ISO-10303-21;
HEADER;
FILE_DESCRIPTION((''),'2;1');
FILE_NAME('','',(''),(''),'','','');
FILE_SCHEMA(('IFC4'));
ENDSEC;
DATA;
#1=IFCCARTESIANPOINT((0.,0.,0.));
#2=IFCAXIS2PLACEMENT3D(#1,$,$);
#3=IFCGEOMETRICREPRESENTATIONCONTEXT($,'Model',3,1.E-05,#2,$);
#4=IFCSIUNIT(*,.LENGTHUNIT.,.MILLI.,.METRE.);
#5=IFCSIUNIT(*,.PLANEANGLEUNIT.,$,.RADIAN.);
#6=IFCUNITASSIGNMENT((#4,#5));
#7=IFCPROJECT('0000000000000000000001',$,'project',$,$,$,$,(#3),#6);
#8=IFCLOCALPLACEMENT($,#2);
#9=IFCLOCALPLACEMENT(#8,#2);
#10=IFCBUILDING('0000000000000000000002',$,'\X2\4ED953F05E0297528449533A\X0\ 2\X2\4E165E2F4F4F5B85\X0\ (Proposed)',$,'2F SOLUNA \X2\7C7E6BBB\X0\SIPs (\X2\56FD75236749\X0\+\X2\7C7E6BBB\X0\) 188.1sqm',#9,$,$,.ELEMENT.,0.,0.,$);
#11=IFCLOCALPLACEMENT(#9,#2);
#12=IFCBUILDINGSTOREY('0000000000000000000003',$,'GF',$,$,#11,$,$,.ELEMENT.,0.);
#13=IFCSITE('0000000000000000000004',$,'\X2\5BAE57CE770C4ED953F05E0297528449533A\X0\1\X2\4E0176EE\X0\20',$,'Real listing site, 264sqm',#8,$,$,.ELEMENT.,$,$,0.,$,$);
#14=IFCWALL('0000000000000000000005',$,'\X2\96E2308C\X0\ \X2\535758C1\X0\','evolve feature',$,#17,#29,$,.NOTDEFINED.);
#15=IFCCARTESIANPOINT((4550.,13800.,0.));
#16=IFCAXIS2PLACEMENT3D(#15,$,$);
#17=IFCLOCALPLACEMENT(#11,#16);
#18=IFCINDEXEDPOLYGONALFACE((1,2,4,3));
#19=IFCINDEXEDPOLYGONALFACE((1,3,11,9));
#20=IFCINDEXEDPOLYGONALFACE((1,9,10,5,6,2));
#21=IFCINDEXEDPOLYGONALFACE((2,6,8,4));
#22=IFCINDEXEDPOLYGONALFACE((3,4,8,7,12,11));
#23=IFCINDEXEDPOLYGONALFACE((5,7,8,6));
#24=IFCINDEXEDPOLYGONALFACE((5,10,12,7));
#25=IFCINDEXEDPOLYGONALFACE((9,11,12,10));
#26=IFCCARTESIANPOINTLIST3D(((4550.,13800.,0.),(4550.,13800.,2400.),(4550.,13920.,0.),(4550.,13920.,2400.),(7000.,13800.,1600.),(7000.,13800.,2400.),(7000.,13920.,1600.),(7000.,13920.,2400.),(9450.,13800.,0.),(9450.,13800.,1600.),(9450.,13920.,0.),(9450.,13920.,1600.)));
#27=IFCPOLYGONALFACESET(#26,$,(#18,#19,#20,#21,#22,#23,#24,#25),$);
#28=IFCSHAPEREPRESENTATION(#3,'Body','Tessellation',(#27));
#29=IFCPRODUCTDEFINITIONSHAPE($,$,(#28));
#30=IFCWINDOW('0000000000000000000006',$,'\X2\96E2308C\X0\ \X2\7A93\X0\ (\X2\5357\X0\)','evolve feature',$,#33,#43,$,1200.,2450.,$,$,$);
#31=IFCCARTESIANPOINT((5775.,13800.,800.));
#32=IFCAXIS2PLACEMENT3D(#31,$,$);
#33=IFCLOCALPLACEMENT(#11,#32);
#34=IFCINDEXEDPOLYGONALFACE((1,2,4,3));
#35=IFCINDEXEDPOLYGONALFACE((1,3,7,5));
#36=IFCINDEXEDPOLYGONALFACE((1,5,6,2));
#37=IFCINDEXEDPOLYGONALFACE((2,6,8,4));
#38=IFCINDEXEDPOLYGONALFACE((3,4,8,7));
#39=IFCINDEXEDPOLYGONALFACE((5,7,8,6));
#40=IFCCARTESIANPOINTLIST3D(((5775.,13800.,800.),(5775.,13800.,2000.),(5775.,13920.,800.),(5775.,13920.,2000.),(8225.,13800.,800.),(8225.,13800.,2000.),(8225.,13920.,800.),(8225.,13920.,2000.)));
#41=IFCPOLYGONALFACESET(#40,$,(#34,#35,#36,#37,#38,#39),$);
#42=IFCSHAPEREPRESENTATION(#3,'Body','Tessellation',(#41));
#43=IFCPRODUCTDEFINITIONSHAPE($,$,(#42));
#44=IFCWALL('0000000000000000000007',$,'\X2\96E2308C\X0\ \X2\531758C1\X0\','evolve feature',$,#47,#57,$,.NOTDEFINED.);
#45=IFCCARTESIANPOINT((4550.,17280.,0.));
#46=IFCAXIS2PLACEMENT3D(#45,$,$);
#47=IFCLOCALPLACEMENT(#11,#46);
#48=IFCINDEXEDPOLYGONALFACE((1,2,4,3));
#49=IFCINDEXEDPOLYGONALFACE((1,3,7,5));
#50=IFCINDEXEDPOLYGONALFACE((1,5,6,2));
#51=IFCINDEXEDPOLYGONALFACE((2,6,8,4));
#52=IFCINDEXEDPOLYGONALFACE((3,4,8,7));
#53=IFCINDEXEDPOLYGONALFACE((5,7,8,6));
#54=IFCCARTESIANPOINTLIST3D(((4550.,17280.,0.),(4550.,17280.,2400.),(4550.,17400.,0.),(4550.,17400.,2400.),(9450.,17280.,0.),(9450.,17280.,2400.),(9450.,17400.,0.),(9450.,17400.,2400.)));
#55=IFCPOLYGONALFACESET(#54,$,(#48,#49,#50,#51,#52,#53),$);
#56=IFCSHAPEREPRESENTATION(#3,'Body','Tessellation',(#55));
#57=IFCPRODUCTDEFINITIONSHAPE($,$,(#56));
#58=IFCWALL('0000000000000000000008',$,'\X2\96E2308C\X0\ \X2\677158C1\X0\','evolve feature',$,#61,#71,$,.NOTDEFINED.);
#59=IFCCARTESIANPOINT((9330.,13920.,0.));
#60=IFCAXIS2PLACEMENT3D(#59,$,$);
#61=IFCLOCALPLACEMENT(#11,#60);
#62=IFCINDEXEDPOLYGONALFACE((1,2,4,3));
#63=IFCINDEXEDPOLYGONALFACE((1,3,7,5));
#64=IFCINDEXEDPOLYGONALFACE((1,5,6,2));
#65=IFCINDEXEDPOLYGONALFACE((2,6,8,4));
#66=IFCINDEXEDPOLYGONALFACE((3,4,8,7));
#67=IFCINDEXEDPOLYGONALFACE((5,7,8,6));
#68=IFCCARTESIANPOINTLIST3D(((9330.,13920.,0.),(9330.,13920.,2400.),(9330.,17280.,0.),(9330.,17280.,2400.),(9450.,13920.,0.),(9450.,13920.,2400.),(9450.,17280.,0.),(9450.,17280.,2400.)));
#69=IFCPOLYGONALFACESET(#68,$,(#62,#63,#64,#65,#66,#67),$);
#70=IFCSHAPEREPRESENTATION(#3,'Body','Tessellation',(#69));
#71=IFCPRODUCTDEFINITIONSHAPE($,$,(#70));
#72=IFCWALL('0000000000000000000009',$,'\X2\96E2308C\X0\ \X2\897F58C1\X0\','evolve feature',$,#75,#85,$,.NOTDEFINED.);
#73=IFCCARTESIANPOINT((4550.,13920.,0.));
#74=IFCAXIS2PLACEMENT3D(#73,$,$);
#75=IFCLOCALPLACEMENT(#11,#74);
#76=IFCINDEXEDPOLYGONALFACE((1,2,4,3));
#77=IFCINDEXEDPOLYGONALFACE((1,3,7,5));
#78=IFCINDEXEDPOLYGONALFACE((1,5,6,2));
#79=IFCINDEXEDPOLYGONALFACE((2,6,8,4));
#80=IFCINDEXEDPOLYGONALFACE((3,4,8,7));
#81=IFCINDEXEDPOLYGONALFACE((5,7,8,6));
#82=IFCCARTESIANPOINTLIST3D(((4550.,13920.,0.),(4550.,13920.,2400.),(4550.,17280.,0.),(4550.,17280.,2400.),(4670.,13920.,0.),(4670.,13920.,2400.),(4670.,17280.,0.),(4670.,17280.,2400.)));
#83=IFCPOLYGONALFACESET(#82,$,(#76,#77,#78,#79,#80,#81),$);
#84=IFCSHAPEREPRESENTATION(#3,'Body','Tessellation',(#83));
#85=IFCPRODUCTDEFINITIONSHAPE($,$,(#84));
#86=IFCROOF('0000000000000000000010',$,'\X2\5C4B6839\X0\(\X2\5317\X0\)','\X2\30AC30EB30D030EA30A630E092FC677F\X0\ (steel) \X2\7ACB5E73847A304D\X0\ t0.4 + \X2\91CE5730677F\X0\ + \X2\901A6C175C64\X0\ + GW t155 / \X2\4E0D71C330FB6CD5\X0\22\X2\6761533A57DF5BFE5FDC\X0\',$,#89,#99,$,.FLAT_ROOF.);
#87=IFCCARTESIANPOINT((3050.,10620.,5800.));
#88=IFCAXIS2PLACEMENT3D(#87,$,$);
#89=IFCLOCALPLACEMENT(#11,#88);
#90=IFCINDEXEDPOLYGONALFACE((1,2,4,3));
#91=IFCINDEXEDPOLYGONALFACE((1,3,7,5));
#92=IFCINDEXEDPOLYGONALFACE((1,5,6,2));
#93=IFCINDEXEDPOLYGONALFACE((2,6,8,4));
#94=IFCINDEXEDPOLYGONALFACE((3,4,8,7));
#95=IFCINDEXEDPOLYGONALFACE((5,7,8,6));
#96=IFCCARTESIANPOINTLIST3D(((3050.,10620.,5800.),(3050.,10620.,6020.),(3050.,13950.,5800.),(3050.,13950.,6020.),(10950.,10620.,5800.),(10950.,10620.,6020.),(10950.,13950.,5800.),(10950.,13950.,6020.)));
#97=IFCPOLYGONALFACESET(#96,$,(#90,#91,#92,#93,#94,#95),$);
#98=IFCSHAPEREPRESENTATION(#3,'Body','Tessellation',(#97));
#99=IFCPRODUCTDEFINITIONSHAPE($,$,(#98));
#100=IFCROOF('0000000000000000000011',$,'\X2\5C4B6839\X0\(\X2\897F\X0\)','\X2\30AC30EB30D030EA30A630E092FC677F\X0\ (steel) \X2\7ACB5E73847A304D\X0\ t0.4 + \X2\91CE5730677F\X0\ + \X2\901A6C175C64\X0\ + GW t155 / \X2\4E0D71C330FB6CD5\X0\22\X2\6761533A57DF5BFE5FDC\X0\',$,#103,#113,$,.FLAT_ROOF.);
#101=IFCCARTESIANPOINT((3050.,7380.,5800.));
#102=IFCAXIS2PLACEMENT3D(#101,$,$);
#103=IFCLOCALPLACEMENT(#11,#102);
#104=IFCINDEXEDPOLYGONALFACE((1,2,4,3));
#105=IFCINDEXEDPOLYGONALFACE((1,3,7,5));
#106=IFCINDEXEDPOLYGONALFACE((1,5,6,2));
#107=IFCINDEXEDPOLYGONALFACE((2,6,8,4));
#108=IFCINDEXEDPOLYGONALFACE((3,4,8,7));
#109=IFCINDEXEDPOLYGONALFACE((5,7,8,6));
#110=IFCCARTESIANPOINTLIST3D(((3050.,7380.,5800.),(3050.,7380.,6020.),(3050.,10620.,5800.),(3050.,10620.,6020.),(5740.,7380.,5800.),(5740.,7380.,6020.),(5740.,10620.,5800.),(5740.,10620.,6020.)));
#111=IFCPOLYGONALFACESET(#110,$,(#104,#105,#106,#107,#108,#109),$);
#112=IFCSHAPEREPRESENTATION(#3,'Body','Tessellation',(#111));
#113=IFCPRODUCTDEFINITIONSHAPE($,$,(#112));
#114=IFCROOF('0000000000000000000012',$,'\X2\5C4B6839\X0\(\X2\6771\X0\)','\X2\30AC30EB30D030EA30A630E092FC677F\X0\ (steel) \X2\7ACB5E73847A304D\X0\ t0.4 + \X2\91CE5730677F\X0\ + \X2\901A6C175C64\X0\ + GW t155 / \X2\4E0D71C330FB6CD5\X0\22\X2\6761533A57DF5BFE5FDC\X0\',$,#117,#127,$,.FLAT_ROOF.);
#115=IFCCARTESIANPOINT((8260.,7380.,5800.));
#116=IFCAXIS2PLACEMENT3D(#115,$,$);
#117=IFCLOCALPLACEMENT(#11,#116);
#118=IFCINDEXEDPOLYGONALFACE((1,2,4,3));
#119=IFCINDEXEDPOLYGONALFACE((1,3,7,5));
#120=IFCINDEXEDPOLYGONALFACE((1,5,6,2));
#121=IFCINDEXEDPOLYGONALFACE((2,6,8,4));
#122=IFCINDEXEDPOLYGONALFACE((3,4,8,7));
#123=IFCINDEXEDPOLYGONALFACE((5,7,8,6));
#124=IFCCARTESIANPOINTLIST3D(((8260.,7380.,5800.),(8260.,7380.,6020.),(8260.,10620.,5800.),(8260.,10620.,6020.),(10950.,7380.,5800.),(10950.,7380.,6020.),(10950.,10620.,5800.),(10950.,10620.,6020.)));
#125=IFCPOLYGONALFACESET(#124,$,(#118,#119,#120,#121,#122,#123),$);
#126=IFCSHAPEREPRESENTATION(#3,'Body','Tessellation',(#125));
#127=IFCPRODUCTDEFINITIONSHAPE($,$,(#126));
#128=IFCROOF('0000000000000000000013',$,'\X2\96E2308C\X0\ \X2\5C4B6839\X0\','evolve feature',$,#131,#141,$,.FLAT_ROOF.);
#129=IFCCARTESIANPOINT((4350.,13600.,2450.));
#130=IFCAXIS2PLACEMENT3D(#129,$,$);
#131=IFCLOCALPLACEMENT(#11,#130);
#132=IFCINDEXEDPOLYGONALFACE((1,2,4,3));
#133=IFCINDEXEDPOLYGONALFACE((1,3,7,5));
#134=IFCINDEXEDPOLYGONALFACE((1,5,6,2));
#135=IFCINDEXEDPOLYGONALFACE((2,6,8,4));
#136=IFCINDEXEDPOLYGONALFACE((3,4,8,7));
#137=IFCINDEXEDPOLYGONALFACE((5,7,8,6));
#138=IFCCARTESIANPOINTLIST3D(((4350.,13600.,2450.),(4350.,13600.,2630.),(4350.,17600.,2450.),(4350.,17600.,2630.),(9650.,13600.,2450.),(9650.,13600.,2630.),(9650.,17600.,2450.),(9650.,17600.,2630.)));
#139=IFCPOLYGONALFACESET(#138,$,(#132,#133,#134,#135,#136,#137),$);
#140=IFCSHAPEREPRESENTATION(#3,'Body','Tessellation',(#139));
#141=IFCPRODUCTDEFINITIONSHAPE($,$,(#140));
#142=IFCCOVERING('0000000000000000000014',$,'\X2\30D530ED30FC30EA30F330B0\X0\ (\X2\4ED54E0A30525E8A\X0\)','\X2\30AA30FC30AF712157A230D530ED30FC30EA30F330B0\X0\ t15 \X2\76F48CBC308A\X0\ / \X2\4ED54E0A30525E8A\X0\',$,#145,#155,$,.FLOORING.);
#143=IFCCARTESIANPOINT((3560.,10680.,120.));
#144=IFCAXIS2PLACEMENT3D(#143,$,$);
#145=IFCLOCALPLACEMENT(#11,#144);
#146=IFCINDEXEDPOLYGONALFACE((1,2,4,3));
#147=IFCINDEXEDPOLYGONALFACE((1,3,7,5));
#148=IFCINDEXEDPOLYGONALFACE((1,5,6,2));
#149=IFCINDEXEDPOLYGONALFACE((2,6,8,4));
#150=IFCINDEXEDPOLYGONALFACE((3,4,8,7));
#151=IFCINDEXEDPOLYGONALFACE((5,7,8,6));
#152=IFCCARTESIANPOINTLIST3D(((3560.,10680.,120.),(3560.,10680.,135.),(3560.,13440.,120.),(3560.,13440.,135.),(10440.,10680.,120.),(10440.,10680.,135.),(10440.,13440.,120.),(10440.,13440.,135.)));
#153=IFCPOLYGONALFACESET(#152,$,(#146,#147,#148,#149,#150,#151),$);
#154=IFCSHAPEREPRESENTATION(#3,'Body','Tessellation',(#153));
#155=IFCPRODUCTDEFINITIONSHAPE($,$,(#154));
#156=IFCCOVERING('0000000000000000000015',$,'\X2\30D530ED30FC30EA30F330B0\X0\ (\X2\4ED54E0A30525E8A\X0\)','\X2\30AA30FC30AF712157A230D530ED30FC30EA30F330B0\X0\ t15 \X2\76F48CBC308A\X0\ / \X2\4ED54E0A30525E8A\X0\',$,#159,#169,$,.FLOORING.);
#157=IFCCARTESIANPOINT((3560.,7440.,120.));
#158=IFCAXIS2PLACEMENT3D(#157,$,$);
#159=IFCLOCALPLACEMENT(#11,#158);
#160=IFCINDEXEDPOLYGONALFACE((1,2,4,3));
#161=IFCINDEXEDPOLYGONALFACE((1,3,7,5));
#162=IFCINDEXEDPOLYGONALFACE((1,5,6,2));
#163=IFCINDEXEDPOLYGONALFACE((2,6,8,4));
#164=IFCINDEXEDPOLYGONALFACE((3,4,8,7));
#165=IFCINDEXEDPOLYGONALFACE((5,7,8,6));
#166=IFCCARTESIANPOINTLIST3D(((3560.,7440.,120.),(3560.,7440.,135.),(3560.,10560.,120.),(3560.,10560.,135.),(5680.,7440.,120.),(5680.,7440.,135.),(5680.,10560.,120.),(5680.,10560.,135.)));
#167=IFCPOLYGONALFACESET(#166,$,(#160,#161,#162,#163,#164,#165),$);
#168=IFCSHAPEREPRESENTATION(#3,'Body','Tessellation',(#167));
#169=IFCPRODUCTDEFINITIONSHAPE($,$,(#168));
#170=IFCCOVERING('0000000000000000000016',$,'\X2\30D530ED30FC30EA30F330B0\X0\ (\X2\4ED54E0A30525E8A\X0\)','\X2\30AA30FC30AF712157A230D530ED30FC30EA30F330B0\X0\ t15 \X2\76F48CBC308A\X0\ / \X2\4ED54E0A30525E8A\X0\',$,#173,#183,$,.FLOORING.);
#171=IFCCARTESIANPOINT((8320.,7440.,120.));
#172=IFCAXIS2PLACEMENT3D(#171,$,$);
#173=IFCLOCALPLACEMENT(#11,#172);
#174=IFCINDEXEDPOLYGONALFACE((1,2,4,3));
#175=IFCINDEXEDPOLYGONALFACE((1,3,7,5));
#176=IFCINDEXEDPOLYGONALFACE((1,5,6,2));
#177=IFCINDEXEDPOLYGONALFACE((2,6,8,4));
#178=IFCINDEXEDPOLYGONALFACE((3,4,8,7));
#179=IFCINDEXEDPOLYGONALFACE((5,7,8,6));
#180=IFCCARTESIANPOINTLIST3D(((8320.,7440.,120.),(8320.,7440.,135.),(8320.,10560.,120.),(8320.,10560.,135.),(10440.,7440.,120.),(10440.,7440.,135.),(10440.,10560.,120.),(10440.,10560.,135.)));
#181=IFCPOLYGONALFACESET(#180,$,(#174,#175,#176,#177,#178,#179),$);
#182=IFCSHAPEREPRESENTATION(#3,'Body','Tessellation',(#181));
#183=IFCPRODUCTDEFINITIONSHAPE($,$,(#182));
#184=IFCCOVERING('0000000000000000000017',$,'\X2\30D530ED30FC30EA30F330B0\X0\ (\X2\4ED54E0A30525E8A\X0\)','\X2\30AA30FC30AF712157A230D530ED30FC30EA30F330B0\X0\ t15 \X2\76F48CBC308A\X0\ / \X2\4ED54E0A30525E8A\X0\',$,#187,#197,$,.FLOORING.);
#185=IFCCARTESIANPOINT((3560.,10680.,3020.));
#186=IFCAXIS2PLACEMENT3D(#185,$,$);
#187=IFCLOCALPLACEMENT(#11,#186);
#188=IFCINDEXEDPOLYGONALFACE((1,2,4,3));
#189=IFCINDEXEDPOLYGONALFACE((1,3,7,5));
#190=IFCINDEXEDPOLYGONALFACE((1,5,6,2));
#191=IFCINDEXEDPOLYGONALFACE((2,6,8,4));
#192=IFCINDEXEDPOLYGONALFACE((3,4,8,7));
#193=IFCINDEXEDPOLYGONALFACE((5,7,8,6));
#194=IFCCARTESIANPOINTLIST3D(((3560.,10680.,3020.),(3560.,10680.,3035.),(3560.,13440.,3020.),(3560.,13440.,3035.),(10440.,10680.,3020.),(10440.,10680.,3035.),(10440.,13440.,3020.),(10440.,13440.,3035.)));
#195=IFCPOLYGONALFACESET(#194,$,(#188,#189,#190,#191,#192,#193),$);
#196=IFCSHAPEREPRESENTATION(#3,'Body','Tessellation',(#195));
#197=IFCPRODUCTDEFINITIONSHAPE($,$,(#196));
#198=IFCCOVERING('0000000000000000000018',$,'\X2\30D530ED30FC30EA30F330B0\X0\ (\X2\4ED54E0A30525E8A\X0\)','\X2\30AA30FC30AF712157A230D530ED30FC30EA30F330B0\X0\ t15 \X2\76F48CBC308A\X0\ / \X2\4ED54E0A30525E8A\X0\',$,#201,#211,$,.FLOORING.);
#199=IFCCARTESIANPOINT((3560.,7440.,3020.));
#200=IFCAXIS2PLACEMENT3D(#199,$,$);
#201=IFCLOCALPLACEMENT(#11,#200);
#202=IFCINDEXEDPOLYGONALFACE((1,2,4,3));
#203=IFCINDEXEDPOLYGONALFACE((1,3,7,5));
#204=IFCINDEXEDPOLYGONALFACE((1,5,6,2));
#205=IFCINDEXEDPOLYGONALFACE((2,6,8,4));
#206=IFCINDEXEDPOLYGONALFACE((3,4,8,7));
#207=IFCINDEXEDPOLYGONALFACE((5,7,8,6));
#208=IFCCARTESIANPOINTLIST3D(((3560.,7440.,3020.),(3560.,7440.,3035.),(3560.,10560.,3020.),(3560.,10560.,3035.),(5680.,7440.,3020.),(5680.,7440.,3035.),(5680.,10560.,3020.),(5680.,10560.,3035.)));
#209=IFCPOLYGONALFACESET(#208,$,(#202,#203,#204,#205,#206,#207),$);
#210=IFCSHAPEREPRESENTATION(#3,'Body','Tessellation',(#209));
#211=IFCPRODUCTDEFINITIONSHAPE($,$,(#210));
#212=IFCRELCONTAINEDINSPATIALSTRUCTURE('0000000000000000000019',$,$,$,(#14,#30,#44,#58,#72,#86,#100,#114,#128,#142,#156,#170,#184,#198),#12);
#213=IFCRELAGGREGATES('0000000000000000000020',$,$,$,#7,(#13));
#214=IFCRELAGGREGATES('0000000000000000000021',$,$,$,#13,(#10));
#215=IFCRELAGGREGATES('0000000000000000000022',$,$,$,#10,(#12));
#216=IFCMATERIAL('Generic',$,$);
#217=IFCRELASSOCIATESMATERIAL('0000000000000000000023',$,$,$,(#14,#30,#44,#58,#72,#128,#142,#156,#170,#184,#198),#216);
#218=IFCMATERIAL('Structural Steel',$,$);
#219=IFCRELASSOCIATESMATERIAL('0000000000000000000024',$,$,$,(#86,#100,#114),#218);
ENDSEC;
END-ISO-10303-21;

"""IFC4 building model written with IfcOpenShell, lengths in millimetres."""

from ifc_helpers import new_model, si_unit, frame, frame_2d, origin, place, context, project, spatial, rectangle, extrude, material, element, fill, save


model = new_model("IFC4")

# Units and contexts
model_context = context("Model", 3, precision=1e-05, world=origin())
ifc_project = project(units=[si_unit("LENGTHUNIT", "METRE", prefix="MILLI"), si_unit("PLANEANGLEUNIT", "RADIAN")], contexts=[model_context])

# Site, building, storey
site_placement = place(None, origin())
site = spatial("IfcSite", under=ifc_project, at=site_placement, Name="宮城県仙台市青葉区1丁目20", ObjectType="Real listing site, 264sqm", CompositionType="ELEMENT", RefElevation=0.0)
building_placement = place(site_placement, origin())
building = spatial("IfcBuilding", under=site, at=building_placement, Name="仙台市青葉区 2世帯住宅 (Proposed)", ObjectType="2F SOLUNA 籾殻SIPs (国産杉+籾殻) 188.1sqm", CompositionType="ELEMENT", ElevationOfRefHeight=0.0, ElevationOfTerrain=0.0)
storey_placement = place(building_placement, origin())
storey = spatial("IfcBuildingStorey", under=building, at=storey_placement, Name="GF", CompositionType="ELEMENT", Elevation=0.0)

# Shared definitions
ifc_material_1 = material(Name="Generic")

# Wall, opening, window
wall_1_placement = place(storey_placement, frame((4550.0, 13800.0, 0.0)))
wall_1 = element("IfcWall", 1, at=wall_1_placement, inside=storey, material=ifc_material_1, Name="離れ 南壁", Description="evolve feature", PredefinedType="NOTDEFINED", context=model_context, shape_type="SweptSolid", body=[
    extrude(rectangle(XDim=4900.0, YDim=120.0, at=frame_2d((2450.0, 60.0))), frame((4550.0, 13800.0, 0.0)), (0.0, 0.0, 1.0), 2400.0),
])
opening_1_placement = place(storey_placement, frame((5775.0, 13800.0, 800.0)))
opening_1 = element("IfcOpeningElement", 2, at=opening_1_placement, cuts=wall_1, PredefinedType="NOTDEFINED", context=model_context, shape_type="SweptSolid", body=[
    extrude(rectangle(XDim=2450.0, YDim=120.0, at=frame_2d((1225.0, 60.0))), frame((5775.0, 13800.0, 800.0)), (0.0, 0.0, 1.0), 1200.0),
])
window_1_placement = place(storey_placement, frame((5775.0, 13800.0, 800.0)))
window_1 = element("IfcWindow", 3, at=window_1_placement, inside=storey, material=ifc_material_1, Name="離れ 窓 (南)", Description="evolve feature", OverallHeight=1200.0, OverallWidth=2450.0, context=model_context, shape_type="SweptSolid", body=[
    extrude(rectangle(XDim=2450.0, YDim=120.0, at=frame_2d((1225.0, 60.0))), frame((5775.0, 13800.0, 800.0)), (0.0, 0.0, 1.0), 1200.0),
])
fill(opening_1, window_1)

# Walls
wall_2_placement = place(storey_placement, frame((4550.0, 17280.0, 0.0)))
element("IfcWall", 4, at=wall_2_placement, inside=storey, material=ifc_material_1, Name="離れ 北壁", Description="evolve feature", PredefinedType="NOTDEFINED", context=model_context, shape_type="SweptSolid", body=[
    extrude(rectangle(XDim=4900.0, YDim=120.0, at=frame_2d((2450.0, 60.0))), frame((4550.0, 17280.0, 0.0)), (0.0, 0.0, 1.0), 2400.0),
])
wall_3_placement = place(storey_placement, frame((9330.0, 13920.0, 0.0)))
element("IfcWall", 5, at=wall_3_placement, inside=storey, material=ifc_material_1, Name="離れ 東壁", Description="evolve feature", PredefinedType="NOTDEFINED", context=model_context, shape_type="SweptSolid", body=[
    extrude(rectangle(XDim=120.0, YDim=3360.0, at=frame_2d((60.0, 1680.0))), frame((9330.0, 13920.0, 0.0)), (0.0, 0.0, 1.0), 2400.0),
])
wall_4_placement = place(storey_placement, frame((4550.0, 13920.0, 0.0)))
element("IfcWall", 6, at=wall_4_placement, inside=storey, material=ifc_material_1, Name="離れ 西壁", Description="evolve feature", PredefinedType="NOTDEFINED", context=model_context, shape_type="SweptSolid", body=[
    extrude(rectangle(XDim=120.0, YDim=3360.0, at=frame_2d((60.0, 1680.0))), frame((4550.0, 13920.0, 0.0)), (0.0, 0.0, 1.0), 2400.0),
])

# Roofs
ifc_material_2 = material(Name="Structural Steel")
for number, where, name in (
    (7, (3050.0, 10620.0, 5800.0), "屋根(北)"),
):
    element("IfcRoof", number, at=place(storey_placement, frame(where)), inside=storey, material=ifc_material_2, Name=name, Description="ガルバリウム鋼板 (steel) 立平葺き t0.4 + 野地板 + 通気層 + GW t155 / 不燃・法22条区域対応", PredefinedType="FLAT_ROOF", context=model_context, shape_type="SweptSolid", body=[
        extrude(rectangle(XDim=7900.0, YDim=3330.0, at=frame_2d((3950.0, 1665.0))), frame((3050.0, 10620.0, 5800.0)), (0.0, 0.0, 1.0), 220.0),
    ])
roof_1_placement = place(storey_placement, frame((3050.0, 7380.0, 5800.0)))
element("IfcRoof", 8, at=roof_1_placement, inside=storey, material=ifc_material_2, Name="屋根(西)", Description="ガルバリウム鋼板 (steel) 立平葺き t0.4 + 野地板 + 通気層 + GW t155 / 不燃・法22条区域対応", PredefinedType="FLAT_ROOF", context=model_context, shape_type="SweptSolid", body=[
    extrude(rectangle(XDim=2690.0, YDim=3240.0, at=frame_2d((1345.0, 1620.0))), frame((3050.0, 7380.0, 5800.0)), (0.0, 0.0, 1.0), 220.0),
])
roof_2_placement = place(storey_placement, frame((8260.0, 7380.0, 5800.0)))
element("IfcRoof", 9, at=roof_2_placement, inside=storey, material=ifc_material_2, Name="屋根(東)", Description="ガルバリウム鋼板 (steel) 立平葺き t0.4 + 野地板 + 通気層 + GW t155 / 不燃・法22条区域対応", PredefinedType="FLAT_ROOF", context=model_context, shape_type="SweptSolid", body=[
    extrude(rectangle(XDim=2690.0, YDim=3240.0, at=frame_2d((1345.0, 1620.0))), frame((8260.0, 7380.0, 5800.0)), (0.0, 0.0, 1.0), 220.0),
])
roof_3_placement = place(storey_placement, frame((4350.0, 13600.0, 2450.0)))
element("IfcRoof", 10, at=roof_3_placement, inside=storey, material=ifc_material_1, Name="離れ 屋根", Description="evolve feature", PredefinedType="FLAT_ROOF", context=model_context, shape_type="SweptSolid", body=[
    extrude(rectangle(XDim=5300.0, YDim=4000.0, at=frame_2d((2650.0, 2000.0))), frame((4350.0, 13600.0, 2450.0)), (0.0, 0.0, 1.0), 180.0),
])

# Coverings
covering_1_placement = place(storey_placement, frame((3560.0, 10680.0, 120.0)))
element("IfcCovering", 11, at=covering_1_placement, inside=storey, material=ifc_material_1, Name="フローリング (仕上げ床)", Description="オーク無垢フローリング t15 直貼り / 仕上げ床", PredefinedType="FLOORING", context=model_context, shape_type="SweptSolid", body=[
    extrude(rectangle(XDim=6880.0, YDim=2760.0, at=frame_2d((3440.0, 1380.0))), frame((3560.0, 10680.0, 120.0)), (0.0, 0.0, 1.0), 15.0),
])
covering_2_placement = place(storey_placement, frame((3560.0, 7440.0, 120.0)))
element("IfcCovering", 12, at=covering_2_placement, inside=storey, material=ifc_material_1, Name="フローリング (仕上げ床)", Description="オーク無垢フローリング t15 直貼り / 仕上げ床", PredefinedType="FLOORING", context=model_context, shape_type="SweptSolid", body=[
    extrude(rectangle(XDim=2120.0, YDim=3120.0, at=frame_2d((1060.0, 1560.0))), frame((3560.0, 7440.0, 120.0)), (0.0, 0.0, 1.0), 15.0),
])
covering_3_placement = place(storey_placement, frame((8320.0, 7440.0, 120.0)))
element("IfcCovering", 13, at=covering_3_placement, inside=storey, material=ifc_material_1, Name="フローリング (仕上げ床)", Description="オーク無垢フローリング t15 直貼り / 仕上げ床", PredefinedType="FLOORING", context=model_context, shape_type="SweptSolid", body=[
    extrude(rectangle(XDim=2120.0, YDim=3120.0, at=frame_2d((1060.0, 1560.0))), frame((8320.0, 7440.0, 120.0)), (0.0, 0.0, 1.0), 15.0),
])
covering_4_placement = place(storey_placement, frame((3560.0, 10680.0, 3020.0)))
element("IfcCovering", 14, at=covering_4_placement, inside=storey, material=ifc_material_1, Name="フローリング (仕上げ床)", Description="オーク無垢フローリング t15 直貼り / 仕上げ床", PredefinedType="FLOORING", context=model_context, shape_type="SweptSolid", body=[
    extrude(rectangle(XDim=6880.0, YDim=2760.0, at=frame_2d((3440.0, 1380.0))), frame((3560.0, 10680.0, 3020.0)), (0.0, 0.0, 1.0), 15.0),
])
covering_5_placement = place(storey_placement, frame((3560.0, 7440.0, 3020.0)))
element("IfcCovering", 15, at=covering_5_placement, inside=storey, material=ifc_material_1, Name="フローリング (仕上げ床)", Description="オーク無垢フローリング t15 直貼り / 仕上げ床", PredefinedType="FLOORING", context=model_context, shape_type="SweptSolid", body=[
    extrude(rectangle(XDim=2120.0, YDim=3120.0, at=frame_2d((1060.0, 1560.0))), frame((3560.0, 7440.0, 3020.0)), (0.0, 0.0, 1.0), 15.0),
])

save(model, "model.ifc")
